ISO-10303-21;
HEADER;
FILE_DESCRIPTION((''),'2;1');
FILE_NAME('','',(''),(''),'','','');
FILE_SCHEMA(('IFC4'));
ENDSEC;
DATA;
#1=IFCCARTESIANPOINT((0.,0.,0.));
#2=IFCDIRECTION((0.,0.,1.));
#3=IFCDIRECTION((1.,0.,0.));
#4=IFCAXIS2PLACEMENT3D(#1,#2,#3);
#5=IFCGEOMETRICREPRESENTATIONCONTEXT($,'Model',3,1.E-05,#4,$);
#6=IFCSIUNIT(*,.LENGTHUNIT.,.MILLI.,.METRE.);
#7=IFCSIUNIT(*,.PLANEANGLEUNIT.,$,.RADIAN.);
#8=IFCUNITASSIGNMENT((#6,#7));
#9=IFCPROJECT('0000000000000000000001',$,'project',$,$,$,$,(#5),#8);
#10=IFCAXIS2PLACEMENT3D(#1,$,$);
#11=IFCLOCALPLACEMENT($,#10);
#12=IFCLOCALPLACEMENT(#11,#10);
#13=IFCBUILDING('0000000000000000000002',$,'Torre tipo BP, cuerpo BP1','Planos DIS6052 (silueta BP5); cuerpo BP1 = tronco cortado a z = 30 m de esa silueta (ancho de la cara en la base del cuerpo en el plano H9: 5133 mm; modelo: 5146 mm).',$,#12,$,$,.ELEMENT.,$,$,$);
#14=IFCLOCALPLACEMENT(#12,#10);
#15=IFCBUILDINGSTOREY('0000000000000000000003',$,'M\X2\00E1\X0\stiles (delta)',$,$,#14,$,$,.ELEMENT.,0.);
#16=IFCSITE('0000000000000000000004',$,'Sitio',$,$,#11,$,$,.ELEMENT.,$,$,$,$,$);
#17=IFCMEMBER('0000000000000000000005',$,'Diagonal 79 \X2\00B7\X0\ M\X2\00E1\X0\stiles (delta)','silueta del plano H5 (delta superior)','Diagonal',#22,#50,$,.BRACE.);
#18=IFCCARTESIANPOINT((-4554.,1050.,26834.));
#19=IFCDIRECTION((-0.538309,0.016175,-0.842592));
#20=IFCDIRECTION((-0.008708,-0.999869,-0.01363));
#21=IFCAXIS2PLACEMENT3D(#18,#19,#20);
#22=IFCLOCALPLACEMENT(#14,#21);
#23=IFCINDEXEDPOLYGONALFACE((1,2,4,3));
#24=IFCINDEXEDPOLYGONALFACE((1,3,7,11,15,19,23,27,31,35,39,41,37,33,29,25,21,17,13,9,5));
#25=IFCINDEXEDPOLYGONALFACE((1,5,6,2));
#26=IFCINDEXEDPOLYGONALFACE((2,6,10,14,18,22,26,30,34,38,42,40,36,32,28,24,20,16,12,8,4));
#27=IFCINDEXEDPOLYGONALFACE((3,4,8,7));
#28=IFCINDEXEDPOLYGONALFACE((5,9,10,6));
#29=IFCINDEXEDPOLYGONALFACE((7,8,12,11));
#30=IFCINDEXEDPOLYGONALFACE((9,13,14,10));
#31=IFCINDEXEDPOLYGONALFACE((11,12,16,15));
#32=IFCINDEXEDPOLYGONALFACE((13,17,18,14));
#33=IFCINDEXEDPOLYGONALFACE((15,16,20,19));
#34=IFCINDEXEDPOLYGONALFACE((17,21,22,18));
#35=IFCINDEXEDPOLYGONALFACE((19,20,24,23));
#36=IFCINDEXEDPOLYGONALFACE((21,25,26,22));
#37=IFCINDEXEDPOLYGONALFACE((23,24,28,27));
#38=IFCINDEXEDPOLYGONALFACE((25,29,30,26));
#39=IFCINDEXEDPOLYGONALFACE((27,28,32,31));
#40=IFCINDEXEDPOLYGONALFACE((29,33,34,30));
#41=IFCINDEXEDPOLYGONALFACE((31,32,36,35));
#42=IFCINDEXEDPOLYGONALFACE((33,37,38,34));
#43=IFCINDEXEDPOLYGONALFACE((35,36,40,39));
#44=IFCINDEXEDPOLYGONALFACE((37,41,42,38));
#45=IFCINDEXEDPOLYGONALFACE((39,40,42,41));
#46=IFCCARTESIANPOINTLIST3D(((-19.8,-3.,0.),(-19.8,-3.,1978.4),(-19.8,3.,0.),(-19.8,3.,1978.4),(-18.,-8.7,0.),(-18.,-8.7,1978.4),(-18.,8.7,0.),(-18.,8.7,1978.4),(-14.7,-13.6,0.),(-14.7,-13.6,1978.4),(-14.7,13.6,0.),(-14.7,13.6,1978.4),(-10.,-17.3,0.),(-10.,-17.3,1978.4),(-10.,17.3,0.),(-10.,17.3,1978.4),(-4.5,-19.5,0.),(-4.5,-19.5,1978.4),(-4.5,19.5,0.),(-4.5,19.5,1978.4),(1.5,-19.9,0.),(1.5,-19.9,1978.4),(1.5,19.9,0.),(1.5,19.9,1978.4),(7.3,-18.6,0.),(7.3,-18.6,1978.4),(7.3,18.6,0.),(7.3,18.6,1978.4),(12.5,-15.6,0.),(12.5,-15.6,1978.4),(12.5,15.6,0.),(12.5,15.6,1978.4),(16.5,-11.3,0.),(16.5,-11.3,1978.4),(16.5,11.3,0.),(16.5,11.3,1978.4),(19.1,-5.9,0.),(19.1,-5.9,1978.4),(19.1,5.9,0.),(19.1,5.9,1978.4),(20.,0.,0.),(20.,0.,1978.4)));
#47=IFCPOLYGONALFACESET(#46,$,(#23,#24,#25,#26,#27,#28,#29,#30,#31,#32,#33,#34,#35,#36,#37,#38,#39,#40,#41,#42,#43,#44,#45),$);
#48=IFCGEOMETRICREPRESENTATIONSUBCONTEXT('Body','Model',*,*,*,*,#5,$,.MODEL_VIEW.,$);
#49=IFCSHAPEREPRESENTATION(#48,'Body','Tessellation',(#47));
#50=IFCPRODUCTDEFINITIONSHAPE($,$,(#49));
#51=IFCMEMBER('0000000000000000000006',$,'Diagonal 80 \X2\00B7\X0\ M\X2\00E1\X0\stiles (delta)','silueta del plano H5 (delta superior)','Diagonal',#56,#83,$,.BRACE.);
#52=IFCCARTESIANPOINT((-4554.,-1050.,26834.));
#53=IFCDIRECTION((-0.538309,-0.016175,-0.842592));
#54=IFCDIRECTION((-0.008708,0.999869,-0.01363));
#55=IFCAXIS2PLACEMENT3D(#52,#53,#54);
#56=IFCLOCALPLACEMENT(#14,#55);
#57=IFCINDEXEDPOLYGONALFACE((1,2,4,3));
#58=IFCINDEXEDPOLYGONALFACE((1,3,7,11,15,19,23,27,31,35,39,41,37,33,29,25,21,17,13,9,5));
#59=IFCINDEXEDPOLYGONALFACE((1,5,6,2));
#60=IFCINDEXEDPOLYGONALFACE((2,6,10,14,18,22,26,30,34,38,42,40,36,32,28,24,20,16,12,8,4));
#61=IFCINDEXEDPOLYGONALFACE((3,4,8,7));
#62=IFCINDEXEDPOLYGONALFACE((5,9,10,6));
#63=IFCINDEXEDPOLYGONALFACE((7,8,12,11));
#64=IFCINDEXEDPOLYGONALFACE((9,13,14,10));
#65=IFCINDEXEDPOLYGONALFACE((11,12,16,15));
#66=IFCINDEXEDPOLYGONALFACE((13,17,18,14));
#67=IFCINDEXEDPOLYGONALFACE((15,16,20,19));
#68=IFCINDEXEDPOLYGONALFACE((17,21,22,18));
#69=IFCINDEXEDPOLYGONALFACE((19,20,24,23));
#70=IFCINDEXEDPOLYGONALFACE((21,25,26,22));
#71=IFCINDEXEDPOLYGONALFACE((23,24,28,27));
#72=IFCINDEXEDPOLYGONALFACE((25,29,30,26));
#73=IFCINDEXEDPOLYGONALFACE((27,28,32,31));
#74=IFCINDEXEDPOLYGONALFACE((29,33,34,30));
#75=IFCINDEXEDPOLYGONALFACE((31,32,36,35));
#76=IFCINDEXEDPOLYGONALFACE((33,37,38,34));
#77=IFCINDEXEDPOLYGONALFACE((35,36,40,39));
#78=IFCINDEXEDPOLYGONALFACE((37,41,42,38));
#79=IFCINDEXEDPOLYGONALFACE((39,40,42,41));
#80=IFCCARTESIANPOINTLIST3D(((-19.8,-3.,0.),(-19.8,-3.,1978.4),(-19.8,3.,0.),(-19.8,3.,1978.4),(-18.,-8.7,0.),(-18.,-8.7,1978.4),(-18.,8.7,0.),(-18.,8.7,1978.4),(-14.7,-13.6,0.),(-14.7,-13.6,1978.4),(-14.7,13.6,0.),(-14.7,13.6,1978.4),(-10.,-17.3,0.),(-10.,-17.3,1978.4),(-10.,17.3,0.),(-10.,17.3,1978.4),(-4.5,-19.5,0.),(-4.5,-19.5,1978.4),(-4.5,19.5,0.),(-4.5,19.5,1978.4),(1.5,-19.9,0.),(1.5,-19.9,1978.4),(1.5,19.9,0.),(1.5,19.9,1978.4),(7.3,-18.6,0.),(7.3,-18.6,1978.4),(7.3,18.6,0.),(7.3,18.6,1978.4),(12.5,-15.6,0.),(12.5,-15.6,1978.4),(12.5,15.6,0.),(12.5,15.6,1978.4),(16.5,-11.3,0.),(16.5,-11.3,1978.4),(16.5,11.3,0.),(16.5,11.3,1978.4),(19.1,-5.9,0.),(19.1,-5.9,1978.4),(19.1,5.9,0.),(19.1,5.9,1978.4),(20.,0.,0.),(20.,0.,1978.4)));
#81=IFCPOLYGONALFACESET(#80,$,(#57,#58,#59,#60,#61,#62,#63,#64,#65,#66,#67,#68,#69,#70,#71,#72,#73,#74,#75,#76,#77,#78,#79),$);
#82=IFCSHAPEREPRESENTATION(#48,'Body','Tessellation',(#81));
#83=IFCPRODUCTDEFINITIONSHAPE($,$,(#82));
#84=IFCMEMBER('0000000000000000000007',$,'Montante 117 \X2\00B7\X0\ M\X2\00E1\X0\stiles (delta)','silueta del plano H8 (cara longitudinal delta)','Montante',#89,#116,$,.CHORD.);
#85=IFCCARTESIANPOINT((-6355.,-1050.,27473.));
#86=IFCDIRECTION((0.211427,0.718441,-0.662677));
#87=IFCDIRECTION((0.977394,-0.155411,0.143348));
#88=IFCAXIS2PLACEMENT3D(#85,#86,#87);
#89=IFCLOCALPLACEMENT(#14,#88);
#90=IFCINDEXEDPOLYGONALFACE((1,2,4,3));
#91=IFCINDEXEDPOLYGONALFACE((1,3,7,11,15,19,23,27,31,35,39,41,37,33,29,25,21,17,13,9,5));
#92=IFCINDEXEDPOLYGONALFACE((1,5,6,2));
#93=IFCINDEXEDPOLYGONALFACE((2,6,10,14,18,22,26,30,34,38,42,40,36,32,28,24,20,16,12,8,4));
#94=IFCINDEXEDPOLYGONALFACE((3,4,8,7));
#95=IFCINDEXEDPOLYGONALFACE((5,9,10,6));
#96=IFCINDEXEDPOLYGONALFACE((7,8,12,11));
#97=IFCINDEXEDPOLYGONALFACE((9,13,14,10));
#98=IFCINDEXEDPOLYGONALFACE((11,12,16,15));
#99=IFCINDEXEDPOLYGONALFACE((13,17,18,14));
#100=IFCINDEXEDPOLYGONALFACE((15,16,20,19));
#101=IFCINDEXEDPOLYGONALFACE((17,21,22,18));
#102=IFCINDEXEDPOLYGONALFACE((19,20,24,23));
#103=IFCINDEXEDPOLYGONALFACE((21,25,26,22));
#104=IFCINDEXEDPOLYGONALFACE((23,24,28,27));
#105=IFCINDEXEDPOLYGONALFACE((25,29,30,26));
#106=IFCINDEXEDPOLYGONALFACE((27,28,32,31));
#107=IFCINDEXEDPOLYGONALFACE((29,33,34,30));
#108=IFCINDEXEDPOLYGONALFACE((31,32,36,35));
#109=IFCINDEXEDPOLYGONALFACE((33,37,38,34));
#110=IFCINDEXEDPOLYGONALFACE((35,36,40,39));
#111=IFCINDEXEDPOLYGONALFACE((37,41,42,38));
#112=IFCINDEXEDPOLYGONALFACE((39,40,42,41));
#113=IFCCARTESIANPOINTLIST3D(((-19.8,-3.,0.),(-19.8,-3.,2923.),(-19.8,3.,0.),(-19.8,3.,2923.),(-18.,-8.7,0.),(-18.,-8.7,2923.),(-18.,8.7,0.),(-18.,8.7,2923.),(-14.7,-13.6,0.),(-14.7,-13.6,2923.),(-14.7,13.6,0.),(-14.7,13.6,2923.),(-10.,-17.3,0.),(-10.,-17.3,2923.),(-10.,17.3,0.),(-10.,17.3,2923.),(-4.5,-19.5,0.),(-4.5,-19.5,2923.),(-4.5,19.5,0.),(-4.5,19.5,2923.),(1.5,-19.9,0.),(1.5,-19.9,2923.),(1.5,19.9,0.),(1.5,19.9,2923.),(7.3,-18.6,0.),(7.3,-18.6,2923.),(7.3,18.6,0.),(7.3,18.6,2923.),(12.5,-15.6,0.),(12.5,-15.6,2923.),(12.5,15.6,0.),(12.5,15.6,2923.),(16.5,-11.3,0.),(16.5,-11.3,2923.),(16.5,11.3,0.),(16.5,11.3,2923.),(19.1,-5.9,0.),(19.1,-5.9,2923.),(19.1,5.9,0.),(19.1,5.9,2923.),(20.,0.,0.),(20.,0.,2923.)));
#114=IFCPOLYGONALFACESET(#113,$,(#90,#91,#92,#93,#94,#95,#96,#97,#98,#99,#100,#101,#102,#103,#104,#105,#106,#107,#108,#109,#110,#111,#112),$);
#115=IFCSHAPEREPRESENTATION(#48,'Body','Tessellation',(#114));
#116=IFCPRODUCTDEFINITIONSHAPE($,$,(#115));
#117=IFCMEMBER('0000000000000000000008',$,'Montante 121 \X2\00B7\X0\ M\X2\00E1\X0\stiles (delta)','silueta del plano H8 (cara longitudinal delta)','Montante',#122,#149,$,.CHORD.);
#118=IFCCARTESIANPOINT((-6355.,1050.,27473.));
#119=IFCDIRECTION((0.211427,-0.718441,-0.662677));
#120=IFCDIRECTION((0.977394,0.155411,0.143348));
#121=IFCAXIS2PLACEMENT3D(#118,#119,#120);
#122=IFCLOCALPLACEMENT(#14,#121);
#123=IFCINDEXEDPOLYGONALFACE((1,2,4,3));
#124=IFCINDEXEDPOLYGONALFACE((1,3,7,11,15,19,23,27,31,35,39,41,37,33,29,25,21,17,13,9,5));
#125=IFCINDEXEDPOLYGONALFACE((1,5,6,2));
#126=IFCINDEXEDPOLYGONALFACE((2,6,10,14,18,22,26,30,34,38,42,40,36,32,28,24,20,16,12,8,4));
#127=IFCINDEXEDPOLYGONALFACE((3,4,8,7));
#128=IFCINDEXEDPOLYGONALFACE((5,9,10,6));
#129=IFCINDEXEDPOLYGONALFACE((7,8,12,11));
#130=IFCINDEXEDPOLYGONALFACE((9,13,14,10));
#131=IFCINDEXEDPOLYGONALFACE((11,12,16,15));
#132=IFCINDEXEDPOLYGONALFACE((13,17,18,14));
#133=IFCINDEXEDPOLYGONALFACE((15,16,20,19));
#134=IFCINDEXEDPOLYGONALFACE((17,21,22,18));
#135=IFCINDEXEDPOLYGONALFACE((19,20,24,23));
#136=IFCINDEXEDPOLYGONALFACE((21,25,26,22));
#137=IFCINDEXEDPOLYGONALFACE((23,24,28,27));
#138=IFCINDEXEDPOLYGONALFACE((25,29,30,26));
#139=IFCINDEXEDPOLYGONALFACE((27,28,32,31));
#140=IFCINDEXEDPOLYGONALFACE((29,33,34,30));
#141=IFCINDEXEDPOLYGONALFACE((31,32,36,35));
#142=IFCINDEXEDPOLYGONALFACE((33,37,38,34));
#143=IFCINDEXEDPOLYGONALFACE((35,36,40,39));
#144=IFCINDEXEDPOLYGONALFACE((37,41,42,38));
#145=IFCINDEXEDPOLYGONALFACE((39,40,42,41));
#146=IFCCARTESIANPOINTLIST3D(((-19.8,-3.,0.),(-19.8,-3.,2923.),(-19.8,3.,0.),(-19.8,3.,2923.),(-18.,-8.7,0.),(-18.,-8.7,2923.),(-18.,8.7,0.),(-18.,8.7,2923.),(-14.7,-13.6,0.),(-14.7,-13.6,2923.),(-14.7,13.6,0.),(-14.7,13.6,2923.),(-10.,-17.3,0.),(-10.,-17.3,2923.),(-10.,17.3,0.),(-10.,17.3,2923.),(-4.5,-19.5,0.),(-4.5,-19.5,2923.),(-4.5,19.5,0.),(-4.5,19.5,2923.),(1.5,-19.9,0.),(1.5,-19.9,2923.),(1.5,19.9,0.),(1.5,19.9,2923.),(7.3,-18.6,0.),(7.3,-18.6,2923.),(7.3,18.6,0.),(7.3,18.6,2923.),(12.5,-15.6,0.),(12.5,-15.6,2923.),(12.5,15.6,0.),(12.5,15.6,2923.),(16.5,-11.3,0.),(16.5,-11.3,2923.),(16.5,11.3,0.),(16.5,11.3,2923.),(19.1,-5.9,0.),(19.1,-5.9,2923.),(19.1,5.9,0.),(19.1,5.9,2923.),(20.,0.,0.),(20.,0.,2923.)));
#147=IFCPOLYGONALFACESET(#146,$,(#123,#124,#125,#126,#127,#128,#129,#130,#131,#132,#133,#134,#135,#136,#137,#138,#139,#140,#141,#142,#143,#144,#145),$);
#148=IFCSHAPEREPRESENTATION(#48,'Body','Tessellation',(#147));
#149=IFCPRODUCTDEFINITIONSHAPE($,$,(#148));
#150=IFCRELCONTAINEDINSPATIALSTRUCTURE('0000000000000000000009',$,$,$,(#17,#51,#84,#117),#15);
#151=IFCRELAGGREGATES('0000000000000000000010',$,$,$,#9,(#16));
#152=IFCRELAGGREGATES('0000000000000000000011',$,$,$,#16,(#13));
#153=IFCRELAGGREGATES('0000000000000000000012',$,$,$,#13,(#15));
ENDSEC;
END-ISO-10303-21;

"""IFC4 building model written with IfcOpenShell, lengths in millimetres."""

from ifc_helpers import new_model, si_unit, frame, origin, origin_with_axes, place, context, subcontext, project, spatial, circle, extrude, element, save


model = new_model("IFC4")

# Units and contexts
model_context = context("Model", 3, precision=1e-05, world=origin_with_axes())
body_context = subcontext(model_context, "Body", "Model", "MODEL_VIEW")
ifc_project = project(units=[si_unit("LENGTHUNIT", "METRE", prefix="MILLI"), si_unit("PLANEANGLEUNIT", "RADIAN")], contexts=[model_context])

# Site, building, storey
site_placement = place(None, origin())
site = spatial("IfcSite", under=ifc_project, at=site_placement, Name="Sitio", CompositionType="ELEMENT")
building_placement = place(site_placement, origin())
building = spatial("IfcBuilding", under=site, at=building_placement, Name="Torre tipo BP, cuerpo BP1", Description="Planos DIS6052 (silueta BP5); cuerpo BP1 = tronco cortado a z = 30 m de esa silueta (ancho de la cara en la base del cuerpo en el plano H9: 5133 mm; modelo: 5146 mm).", CompositionType="ELEMENT")
storey_placement = place(building_placement, origin())
storey = spatial("IfcBuildingStorey", under=building, at=storey_placement, Name="Mástiles (delta)", CompositionType="ELEMENT", Elevation=0.0)

# Members
for number, where, z_axis, x_axis, name in (
    (1, (-4554.0, 1050.0, 26834.0), (-0.538309, 0.016175, -0.842592), (-0.008708, -0.999869, -0.01363), "Diagonal 79 · Mástiles (delta)"),
    (2, (-4554.0, -1050.0, 26834.0), (-0.538309, -0.016175, -0.842592), (-0.008708, 0.999869, -0.01363), "Diagonal 80 · Mástiles (delta)"),
):
    element("IfcMember", number, at=place(storey_placement, frame(where, z_axis=z_axis, x_axis=x_axis)), inside=storey, Name=name, Description="silueta del plano H5 (delta superior)", ObjectType="Diagonal", PredefinedType="BRACE", context=body_context, shape_type="SweptSolid", body=[
        extrude(circle(Radius=20.0), None, (0.0, 0.0, 1.0), 1978.4),
    ])
member_1_placement = place(storey_placement, frame((-6355.0, -1050.0, 27473.0), z_axis=(0.211427, 0.718441, -0.662677), x_axis=(0.977394, -0.155411, 0.143348)))
element("IfcMember", 3, at=member_1_placement, inside=storey, Name="Montante 117 · Mástiles (delta)", Description="silueta del plano H8 (cara longitudinal delta)", ObjectType="Montante", PredefinedType="CHORD", context=body_context, shape_type="SweptSolid", body=[
    extrude(circle(Radius=20.0), None, (0.0, 0.0, 1.0), 2923.0),
])
member_2_placement = place(storey_placement, frame((-6355.0, 1050.0, 27473.0), z_axis=(0.211427, -0.718441, -0.662677), x_axis=(0.977394, 0.155411, 0.143348)))
element("IfcMember", 4, at=member_2_placement, inside=storey, Name="Montante 121 · Mástiles (delta)", Description="silueta del plano H8 (cara longitudinal delta)", ObjectType="Montante", PredefinedType="CHORD", context=body_context, shape_type="SweptSolid", body=[
    extrude(circle(Radius=20.0), None, (0.0, 0.0, 1.0), 2923.0),
])

save(model, "model.ifc")
